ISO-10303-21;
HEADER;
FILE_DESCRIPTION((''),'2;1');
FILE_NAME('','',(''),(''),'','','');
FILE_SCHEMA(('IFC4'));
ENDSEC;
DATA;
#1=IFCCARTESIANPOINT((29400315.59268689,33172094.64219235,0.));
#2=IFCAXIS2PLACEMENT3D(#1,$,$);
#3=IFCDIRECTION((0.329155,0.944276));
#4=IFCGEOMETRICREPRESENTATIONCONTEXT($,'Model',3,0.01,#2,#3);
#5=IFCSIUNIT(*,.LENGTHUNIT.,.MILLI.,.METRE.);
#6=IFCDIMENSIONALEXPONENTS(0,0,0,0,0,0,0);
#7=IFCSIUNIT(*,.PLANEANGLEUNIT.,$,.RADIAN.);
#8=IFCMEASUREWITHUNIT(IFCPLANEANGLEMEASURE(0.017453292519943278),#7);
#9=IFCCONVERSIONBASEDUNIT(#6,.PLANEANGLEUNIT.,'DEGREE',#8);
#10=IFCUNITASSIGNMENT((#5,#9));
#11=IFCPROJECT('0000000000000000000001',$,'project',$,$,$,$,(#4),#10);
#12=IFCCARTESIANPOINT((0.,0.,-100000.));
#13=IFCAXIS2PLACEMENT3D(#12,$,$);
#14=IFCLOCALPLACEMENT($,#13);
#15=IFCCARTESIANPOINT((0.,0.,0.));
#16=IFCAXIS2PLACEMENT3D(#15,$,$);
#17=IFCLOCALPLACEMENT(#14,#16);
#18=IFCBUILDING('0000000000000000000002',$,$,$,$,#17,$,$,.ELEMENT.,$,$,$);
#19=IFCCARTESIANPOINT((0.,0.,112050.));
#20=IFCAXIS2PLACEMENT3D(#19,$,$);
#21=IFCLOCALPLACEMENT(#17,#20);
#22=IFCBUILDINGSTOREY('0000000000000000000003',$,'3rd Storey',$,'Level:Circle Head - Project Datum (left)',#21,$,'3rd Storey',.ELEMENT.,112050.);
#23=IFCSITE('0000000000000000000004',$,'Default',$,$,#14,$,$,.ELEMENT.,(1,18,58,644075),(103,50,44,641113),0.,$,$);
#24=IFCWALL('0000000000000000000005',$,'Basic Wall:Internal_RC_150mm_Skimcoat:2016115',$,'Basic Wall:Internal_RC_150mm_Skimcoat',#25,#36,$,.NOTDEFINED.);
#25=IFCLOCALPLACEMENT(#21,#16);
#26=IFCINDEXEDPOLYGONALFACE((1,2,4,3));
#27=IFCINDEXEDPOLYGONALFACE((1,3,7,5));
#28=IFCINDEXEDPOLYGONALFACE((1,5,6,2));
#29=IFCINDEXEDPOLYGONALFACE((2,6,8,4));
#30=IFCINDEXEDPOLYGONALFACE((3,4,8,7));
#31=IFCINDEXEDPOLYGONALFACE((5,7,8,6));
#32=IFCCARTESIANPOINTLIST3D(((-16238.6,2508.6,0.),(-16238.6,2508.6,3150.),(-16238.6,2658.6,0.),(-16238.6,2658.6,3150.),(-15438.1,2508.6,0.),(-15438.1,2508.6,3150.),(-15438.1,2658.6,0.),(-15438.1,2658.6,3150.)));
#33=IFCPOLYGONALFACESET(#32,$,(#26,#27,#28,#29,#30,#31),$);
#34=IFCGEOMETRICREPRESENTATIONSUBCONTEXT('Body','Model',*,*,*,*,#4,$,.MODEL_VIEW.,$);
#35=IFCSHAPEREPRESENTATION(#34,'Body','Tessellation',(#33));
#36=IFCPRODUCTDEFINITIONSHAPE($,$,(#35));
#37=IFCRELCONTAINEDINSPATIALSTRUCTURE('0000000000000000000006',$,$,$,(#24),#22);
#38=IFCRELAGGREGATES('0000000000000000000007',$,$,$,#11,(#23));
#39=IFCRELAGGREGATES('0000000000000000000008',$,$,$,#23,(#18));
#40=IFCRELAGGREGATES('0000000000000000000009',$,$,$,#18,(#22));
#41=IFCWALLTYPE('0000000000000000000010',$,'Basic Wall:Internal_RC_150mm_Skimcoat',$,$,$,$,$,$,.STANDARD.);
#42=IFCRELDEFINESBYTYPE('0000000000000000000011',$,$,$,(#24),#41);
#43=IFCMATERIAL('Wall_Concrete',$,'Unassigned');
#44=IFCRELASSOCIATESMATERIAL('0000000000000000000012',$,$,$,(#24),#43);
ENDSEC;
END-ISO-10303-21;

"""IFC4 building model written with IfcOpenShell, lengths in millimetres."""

from ifc_helpers import new_model, entity, si_unit, converted_unit, direction, frame, origin, place, context, subcontext, project, spatial, indexed_curve, outline, extrude, material, type_object, element, save


model = new_model("IFC4")

# Units and contexts
model_context = context("Model", 3, precision=0.01, world=frame((29400315.59268689, 33172094.64219235, 0.0)), true_north=direction((0.329155, 0.944276)))
body_context = subcontext(model_context, "Body", "Model", "MODEL_VIEW")
ifc_project = project(units=[si_unit("LENGTHUNIT", "METRE", prefix="MILLI"), converted_unit("PLANEANGLEUNIT", "DEGREE", entity("IfcPlaneAngleMeasure", 0.017453292519943278), si_unit("PLANEANGLEUNIT", "RADIAN"), dimensions=[0, 0, 0, 0, 0, 0, 0])], contexts=[model_context])

# Site, building, storey
site_placement = place(None, frame((0.0, 0.0, -100000.0)))
site = spatial("IfcSite", under=ifc_project, at=site_placement, Name="Default", CompositionType="ELEMENT", RefLatitude=(1, 18, 58, 644075), RefLongitude=(103, 50, 44, 641113), RefElevation=0.0)
building_placement = place(site_placement, origin())
building = spatial("IfcBuilding", under=site, at=building_placement, CompositionType="ELEMENT")
storey_placement = place(building_placement, frame((0.0, 0.0, 112050.0)))
storey = spatial("IfcBuildingStorey", under=building, at=storey_placement, Name="3rd Storey", ObjectType="Level:Circle Head - Project Datum (left)", LongName="3rd Storey", CompositionType="ELEMENT", Elevation=112050.0)

# Wall
ifc_material_1 = material(Name="Wall_Concrete", Category="Unassigned")
wall_type_1 = type_object("IfcWallType", Name="Basic Wall:Internal_RC_150mm_Skimcoat", PredefinedType="STANDARD")
wall_1_placement = place(storey_placement, frame((-16238.6, 2583.6, 0.0)))
element("IfcWall", 1, at=wall_1_placement, inside=storey, type_object=wall_type_1, material=ifc_material_1, Name="Basic Wall:Internal_RC_150mm_Skimcoat:2016115", ObjectType="Basic Wall:Internal_RC_150mm_Skimcoat", PredefinedType="NOTDEFINED", context=body_context, shape_type="SweptSolid", body=[
    extrude(outline(indexed_curve([(800.5, 75.0), (0.0, 75.0), (0.0, -75.0), (800.5, -75.0), (800.5, 75.0)], self_intersect=False)), origin(), (0.0, 0.0, 1.0), 3150.0),
])

save(model, "model.ifc")
